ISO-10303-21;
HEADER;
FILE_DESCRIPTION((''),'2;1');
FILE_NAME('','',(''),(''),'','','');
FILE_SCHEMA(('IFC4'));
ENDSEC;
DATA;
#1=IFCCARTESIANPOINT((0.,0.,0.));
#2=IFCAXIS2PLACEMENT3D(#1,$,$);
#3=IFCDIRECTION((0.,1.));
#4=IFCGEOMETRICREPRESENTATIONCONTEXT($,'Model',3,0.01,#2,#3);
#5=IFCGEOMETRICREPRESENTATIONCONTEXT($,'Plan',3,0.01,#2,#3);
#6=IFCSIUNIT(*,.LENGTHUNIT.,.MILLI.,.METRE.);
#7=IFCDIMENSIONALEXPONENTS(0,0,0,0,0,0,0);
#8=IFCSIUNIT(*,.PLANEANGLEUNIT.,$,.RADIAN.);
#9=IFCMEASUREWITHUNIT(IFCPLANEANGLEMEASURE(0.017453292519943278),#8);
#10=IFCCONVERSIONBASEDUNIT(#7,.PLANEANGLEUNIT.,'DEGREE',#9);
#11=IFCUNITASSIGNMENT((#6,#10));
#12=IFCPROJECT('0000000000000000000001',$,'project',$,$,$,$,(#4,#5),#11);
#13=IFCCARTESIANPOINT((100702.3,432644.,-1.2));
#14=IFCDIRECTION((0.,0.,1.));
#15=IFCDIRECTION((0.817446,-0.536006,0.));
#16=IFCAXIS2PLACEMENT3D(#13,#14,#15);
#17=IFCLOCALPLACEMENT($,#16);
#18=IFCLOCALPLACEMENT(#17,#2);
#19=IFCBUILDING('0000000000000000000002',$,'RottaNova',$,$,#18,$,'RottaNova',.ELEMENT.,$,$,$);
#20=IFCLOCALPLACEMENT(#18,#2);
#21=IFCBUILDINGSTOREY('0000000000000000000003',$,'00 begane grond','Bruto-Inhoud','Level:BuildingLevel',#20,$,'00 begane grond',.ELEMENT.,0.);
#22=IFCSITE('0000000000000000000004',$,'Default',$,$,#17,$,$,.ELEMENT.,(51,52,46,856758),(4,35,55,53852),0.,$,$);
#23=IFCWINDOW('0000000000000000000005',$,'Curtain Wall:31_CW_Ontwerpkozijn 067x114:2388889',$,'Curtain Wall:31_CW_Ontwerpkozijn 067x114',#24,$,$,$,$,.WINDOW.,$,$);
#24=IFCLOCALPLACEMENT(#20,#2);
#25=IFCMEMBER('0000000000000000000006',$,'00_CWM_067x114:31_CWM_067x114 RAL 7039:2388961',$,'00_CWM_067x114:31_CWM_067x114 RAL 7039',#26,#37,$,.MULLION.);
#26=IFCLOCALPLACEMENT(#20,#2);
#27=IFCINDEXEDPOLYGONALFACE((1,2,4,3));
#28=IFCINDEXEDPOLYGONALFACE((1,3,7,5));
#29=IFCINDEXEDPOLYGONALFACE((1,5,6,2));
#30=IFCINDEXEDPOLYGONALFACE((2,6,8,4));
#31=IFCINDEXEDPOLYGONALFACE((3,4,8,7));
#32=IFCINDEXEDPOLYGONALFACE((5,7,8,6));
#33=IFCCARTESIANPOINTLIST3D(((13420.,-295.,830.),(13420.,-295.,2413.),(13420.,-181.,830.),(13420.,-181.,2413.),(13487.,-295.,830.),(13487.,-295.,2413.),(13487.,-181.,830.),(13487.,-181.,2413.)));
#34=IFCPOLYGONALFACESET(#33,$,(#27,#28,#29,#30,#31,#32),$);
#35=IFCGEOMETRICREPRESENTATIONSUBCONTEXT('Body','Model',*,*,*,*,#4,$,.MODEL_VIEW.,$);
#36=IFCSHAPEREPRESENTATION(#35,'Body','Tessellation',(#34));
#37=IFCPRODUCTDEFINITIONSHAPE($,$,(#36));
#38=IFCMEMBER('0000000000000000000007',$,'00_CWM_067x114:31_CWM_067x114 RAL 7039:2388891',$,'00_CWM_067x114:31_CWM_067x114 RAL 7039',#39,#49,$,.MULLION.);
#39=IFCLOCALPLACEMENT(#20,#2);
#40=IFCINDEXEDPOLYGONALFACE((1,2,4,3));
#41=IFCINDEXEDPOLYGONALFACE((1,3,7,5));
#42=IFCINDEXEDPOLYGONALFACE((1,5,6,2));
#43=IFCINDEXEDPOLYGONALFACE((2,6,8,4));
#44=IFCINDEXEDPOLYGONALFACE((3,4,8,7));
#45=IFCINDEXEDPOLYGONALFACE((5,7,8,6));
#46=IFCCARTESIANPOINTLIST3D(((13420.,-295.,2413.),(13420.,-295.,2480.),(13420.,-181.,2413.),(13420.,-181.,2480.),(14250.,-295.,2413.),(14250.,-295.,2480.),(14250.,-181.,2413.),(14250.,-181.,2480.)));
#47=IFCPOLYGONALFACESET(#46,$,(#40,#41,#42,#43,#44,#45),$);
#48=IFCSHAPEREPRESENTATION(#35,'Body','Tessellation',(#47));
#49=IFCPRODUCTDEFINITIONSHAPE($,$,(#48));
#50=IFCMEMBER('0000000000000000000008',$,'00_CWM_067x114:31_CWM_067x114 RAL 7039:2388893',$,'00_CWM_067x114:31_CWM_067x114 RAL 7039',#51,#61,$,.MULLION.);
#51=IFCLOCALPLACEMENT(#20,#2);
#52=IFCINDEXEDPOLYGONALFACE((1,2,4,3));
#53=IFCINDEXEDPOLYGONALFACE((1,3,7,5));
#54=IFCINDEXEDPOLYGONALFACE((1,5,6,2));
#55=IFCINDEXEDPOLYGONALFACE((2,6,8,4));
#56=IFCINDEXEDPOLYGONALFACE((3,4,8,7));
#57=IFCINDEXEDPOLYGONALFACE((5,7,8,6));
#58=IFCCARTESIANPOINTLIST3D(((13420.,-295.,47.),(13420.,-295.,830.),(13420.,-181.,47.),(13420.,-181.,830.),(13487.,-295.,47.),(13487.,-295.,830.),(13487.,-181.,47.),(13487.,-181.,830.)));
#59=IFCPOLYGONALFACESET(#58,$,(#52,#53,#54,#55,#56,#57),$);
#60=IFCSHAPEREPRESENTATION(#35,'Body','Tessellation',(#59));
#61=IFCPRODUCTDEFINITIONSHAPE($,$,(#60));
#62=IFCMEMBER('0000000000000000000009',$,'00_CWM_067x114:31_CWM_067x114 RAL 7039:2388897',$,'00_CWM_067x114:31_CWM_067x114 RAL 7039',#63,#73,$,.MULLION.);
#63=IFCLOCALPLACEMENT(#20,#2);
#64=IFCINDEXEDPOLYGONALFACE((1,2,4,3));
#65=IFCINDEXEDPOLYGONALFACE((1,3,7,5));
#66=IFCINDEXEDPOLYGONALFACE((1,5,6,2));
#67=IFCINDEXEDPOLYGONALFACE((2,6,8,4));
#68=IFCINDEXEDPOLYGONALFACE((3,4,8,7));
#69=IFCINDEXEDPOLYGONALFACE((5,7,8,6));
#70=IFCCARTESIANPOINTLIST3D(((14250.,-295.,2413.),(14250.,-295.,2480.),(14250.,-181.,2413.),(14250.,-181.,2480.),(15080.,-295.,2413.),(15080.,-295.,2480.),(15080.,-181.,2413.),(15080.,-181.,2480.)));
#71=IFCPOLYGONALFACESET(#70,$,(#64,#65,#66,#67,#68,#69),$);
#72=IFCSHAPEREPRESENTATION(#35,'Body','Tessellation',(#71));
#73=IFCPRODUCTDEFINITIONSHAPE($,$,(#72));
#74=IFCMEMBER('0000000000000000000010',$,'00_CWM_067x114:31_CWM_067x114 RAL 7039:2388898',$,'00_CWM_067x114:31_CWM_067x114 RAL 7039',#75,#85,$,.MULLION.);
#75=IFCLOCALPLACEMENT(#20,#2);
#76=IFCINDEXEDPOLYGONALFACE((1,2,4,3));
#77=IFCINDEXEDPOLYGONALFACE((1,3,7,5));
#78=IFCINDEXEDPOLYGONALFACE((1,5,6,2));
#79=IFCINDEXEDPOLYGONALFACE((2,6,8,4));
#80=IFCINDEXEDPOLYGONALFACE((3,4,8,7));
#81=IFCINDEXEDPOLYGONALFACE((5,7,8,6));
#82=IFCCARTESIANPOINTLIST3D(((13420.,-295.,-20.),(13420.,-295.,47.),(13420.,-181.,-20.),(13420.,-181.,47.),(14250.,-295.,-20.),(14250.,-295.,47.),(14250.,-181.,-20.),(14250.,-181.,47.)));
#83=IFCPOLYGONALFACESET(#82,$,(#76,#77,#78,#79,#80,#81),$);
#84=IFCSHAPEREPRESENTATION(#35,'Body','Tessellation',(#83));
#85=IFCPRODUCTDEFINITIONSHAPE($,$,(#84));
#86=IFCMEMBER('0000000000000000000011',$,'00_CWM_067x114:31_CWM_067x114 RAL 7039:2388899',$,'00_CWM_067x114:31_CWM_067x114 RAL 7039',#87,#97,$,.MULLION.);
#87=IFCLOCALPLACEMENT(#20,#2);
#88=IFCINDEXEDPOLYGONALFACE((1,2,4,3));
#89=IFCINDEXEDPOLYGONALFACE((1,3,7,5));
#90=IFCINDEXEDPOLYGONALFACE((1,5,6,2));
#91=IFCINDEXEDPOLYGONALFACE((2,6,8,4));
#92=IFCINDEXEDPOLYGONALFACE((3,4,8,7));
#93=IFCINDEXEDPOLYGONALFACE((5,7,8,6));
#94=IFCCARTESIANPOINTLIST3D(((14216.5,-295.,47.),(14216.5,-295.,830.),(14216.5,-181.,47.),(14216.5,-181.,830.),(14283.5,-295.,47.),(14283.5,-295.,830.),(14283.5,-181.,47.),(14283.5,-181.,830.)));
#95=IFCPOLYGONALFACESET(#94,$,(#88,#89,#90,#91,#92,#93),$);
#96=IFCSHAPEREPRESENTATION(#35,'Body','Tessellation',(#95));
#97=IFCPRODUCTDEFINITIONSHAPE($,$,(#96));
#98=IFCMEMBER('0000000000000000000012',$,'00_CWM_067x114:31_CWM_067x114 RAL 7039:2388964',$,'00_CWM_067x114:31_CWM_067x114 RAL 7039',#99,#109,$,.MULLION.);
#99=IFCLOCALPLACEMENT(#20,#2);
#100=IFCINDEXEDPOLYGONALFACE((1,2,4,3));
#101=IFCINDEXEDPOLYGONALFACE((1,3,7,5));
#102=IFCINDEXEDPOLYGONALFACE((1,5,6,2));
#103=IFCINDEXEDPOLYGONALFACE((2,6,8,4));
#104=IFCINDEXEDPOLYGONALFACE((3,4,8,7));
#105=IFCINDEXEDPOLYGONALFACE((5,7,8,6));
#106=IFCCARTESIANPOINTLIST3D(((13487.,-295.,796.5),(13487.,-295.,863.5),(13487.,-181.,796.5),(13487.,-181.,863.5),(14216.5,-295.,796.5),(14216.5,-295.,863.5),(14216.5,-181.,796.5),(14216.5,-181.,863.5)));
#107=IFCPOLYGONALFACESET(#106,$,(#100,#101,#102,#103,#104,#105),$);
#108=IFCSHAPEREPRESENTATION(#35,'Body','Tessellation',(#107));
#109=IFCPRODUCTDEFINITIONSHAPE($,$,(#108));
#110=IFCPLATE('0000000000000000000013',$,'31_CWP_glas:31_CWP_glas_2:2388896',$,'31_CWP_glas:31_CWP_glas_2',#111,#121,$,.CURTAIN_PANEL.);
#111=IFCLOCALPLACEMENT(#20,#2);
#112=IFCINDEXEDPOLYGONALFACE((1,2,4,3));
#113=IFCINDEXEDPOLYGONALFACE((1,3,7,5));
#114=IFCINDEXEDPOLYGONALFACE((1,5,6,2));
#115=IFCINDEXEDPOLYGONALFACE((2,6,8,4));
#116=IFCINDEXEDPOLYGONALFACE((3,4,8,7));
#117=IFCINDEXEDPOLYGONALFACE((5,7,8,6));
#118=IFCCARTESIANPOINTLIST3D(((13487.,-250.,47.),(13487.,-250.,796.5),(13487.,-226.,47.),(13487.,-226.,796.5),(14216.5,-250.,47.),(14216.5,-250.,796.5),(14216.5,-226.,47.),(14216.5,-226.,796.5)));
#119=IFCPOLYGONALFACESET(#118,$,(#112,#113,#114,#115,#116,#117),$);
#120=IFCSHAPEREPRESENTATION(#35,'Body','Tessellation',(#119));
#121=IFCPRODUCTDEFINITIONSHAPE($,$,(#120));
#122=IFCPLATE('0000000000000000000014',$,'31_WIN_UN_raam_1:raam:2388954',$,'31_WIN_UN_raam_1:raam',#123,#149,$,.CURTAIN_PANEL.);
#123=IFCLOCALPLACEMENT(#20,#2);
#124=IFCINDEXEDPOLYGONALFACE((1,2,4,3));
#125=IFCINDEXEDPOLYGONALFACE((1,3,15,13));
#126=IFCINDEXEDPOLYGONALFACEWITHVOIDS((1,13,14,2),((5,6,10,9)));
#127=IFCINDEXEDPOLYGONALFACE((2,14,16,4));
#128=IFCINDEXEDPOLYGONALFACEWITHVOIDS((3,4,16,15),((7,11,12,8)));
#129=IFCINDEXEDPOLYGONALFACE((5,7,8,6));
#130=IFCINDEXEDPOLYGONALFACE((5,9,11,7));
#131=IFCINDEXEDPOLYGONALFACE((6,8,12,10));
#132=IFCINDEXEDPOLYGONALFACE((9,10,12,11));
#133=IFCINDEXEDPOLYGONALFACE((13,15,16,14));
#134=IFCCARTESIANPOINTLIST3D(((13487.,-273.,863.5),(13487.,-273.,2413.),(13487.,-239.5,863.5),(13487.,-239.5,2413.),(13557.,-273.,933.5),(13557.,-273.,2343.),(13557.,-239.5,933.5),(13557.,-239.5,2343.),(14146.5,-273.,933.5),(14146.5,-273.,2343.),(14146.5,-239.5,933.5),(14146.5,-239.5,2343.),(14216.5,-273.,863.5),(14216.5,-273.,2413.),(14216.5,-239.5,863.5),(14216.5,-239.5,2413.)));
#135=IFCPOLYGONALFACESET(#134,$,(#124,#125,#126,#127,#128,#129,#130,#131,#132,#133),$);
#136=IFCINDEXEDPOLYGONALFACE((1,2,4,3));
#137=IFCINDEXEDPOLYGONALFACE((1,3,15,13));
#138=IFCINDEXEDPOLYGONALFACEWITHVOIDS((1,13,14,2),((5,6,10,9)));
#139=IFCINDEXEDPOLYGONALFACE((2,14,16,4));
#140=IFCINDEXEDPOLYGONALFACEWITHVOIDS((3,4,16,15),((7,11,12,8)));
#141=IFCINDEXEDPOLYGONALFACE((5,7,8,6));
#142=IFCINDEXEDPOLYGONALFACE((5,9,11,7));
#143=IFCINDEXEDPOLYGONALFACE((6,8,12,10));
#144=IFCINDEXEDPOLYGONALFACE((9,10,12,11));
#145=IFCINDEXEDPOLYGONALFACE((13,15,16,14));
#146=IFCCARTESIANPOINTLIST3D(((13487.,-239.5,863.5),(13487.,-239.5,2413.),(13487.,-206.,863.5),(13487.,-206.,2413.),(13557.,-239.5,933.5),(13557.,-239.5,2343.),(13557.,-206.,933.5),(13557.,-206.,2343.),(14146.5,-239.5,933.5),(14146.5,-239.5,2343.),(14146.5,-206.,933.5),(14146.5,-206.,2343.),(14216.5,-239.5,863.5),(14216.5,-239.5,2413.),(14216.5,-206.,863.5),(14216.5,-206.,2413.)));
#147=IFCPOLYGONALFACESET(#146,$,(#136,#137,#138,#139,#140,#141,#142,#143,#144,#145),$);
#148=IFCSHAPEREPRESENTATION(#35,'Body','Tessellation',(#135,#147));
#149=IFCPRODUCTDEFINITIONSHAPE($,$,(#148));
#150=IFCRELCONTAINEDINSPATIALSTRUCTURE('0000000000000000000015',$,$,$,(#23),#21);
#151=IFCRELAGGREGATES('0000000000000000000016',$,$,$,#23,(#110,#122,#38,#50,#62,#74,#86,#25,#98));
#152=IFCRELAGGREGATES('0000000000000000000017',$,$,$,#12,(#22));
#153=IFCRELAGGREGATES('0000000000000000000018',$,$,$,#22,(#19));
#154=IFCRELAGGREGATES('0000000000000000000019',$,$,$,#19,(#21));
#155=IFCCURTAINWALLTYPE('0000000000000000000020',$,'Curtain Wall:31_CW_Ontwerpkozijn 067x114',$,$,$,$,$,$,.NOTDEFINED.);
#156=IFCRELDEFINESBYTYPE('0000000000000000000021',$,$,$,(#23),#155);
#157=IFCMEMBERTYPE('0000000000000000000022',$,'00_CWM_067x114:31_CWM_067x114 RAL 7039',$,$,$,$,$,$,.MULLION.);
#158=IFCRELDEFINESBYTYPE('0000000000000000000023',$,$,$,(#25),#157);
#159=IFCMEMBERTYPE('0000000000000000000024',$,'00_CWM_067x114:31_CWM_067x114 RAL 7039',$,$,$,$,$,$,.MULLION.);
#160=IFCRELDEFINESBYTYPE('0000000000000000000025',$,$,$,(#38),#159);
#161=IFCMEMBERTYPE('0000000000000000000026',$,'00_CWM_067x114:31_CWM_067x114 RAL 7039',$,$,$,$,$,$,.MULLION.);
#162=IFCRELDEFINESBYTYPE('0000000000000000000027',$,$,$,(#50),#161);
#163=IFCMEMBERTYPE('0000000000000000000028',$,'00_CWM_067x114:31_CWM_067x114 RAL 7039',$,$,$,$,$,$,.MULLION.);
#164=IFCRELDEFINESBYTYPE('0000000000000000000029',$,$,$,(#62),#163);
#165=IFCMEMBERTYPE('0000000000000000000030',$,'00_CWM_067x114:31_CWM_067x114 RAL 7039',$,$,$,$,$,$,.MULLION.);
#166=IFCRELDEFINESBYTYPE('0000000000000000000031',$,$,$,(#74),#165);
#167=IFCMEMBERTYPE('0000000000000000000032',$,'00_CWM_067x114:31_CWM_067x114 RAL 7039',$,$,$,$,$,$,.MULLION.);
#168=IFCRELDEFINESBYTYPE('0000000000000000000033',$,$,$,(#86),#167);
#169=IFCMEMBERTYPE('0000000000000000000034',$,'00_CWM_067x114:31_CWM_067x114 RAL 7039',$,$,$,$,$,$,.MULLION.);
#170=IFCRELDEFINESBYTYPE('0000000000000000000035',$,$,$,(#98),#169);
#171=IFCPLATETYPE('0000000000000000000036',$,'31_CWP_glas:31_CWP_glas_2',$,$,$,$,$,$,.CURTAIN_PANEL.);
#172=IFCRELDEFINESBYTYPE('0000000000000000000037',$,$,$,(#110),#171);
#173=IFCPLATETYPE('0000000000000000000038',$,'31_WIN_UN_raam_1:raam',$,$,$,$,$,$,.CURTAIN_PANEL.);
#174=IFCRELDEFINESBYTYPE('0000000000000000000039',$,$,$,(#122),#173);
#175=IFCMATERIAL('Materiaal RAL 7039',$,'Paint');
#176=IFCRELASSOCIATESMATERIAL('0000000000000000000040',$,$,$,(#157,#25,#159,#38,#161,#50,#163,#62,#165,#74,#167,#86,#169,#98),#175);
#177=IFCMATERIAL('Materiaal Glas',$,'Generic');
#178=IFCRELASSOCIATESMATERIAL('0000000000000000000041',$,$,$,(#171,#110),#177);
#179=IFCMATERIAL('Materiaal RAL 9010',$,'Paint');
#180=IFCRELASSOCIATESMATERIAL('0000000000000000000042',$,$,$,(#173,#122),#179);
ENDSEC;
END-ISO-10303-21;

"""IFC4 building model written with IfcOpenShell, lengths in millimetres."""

from ifc_helpers import new_model, entity, si_unit, converted_unit, direction, frame, origin, place, context, subcontext, project, spatial, indexed_curve, outline, extrude, source, transform, mapped, material, type_object, type_shapes, element, aggregate, save


model = new_model("IFC4")

# Units and contexts
model_context = context("Model", 3, precision=0.01, world=origin(), true_north=direction((0.0, 1.0)))
plan_context = context("Plan", 3, precision=0.01, world=origin(), true_north=direction((0.0, 1.0)))
body_context = subcontext(model_context, "Body", "Model", "MODEL_VIEW")
ifc_project = project(units=[si_unit("LENGTHUNIT", "METRE", prefix="MILLI"), converted_unit("PLANEANGLEUNIT", "DEGREE", entity("IfcPlaneAngleMeasure", 0.017453292519943278), si_unit("PLANEANGLEUNIT", "RADIAN"), dimensions=[0, 0, 0, 0, 0, 0, 0])], contexts=[model_context, plan_context])

# Site, building, storey
site_placement = place(None, frame((100702.3, 432644.0, -1.2), z_axis=(0.0, 0.0, 1.0), x_axis=(0.817446, -0.536006, 0.0)))
site = spatial("IfcSite", under=ifc_project, at=site_placement, Name="Default", CompositionType="ELEMENT", RefLatitude=(51, 52, 46, 856758), RefLongitude=(4, 35, 55, 53852), RefElevation=0.0)
building_placement = place(site_placement, origin())
building = spatial("IfcBuilding", under=site, at=building_placement, Name="RottaNova", LongName="RottaNova", CompositionType="ELEMENT")
storey_placement = place(building_placement, origin())
storey = spatial("IfcBuildingStorey", under=building, at=storey_placement, Name="00 begane grond", Description="Bruto-Inhoud", ObjectType="Level:BuildingLevel", LongName="00 begane grond", CompositionType="ELEMENT", Elevation=0.0)

# Window, members, plates
curtain_wall_type = type_object("IfcCurtainWallType", Name="Curtain Wall:31_CW_Ontwerpkozijn 067x114", PredefinedType="NOTDEFINED")
window_1_placement = place(storey_placement, origin())
window_1 = element("IfcWindow", 1, at=window_1_placement, inside=storey, type_object=curtain_wall_type, Name="Curtain Wall:31_CW_Ontwerpkozijn 067x114:2388889", ObjectType="Curtain Wall:31_CW_Ontwerpkozijn 067x114", PredefinedType="WINDOW")
ifc_material_1 = material(Name="Materiaal RAL 7039", Category="Paint")
member_type_1 = type_object("IfcMemberType", Name="00_CWM_067x114:31_CWM_067x114 RAL 7039", PredefinedType="MULLION", material=ifc_material_1)
shared_shape_1 = source(origin(), body_context, "Body", "SweptSolid", [
    extrude(outline(indexed_curve([(-33.5, -57.0), (33.5, -57.0), (33.5, 57.0), (-33.5, 57.0), (-33.5, -57.0)], self_intersect=False)), frame((-33.5, -57.0, -1583.0), z_axis=(0.0, 0.0, 1.0), x_axis=(-1.0, 0.0, 0.0)), (0.0, 0.0, 1.0), 1583.0),
])
type_shapes(member_type_1, [shared_shape_1])
member_1_placement = place(window_1_placement, frame((13420.0, -181.0, 830.0), z_axis=(0.0, 0.0, -1.0), x_axis=(-1.0, 0.0, 0.0)))
member_1 = element("IfcMember", 2, at=member_1_placement, type_object=member_type_1, material=ifc_material_1, Name="00_CWM_067x114:31_CWM_067x114 RAL 7039:2388961", ObjectType="00_CWM_067x114:31_CWM_067x114 RAL 7039", PredefinedType="MULLION", context=body_context, shape_type="MappedRepresentation", body=[
    mapped(shared_shape_1, transform((0.0, 0.0, 0.0), scale=1.0)),
])
member_type_2 = type_object("IfcMemberType", Name="00_CWM_067x114:31_CWM_067x114 RAL 7039", PredefinedType="MULLION", material=ifc_material_1)
shared_shape_2 = source(origin(), body_context, "Body", "SweptSolid", [
    extrude(outline(indexed_curve([(-33.5, -57.0), (33.5, -57.0), (33.5, 57.0), (-33.5, 57.0), (-33.5, -57.0)], self_intersect=False)), frame((-33.5, -57.0, -830.0), z_axis=(0.0, 0.0, 1.0), x_axis=(-1.0, 0.0, 0.0)), (0.0, 0.0, 1.0), 830.0),
])
type_shapes(member_type_2, [shared_shape_2])
member_2_placement = place(window_1_placement, frame((13420.0, -181.0, 2480.0), z_axis=(-1.0, 0.0, 0.0), x_axis=(0.0, 0.0, 1.0)))
member_2 = element("IfcMember", 3, at=member_2_placement, type_object=member_type_2, material=ifc_material_1, Name="00_CWM_067x114:31_CWM_067x114 RAL 7039:2388891", ObjectType="00_CWM_067x114:31_CWM_067x114 RAL 7039", PredefinedType="MULLION", context=body_context, shape_type="MappedRepresentation", body=[
    mapped(shared_shape_2, transform((0.0, 0.0, 0.0), scale=1.0)),
])
member_type_3 = type_object("IfcMemberType", Name="00_CWM_067x114:31_CWM_067x114 RAL 7039", PredefinedType="MULLION", material=ifc_material_1)
shared_shape_3 = source(origin(), body_context, "Body", "SweptSolid", [
    extrude(outline(indexed_curve([(-33.5, -57.0), (33.5, -57.0), (33.5, 57.0), (-33.5, 57.0), (-33.5, -57.0)], self_intersect=False)), frame((-33.5, -57.0, -783.0), z_axis=(0.0, 0.0, 1.0), x_axis=(-1.0, 0.0, 0.0)), (0.0, 0.0, 1.0), 783.0),
])
type_shapes(member_type_3, [shared_shape_3])
member_3_placement = place(window_1_placement, frame((13420.0, -181.0, 47.0), z_axis=(0.0, 0.0, -1.0), x_axis=(-1.0, 0.0, 0.0)))
member_3 = element("IfcMember", 4, at=member_3_placement, type_object=member_type_3, material=ifc_material_1, Name="00_CWM_067x114:31_CWM_067x114 RAL 7039:2388893", ObjectType="00_CWM_067x114:31_CWM_067x114 RAL 7039", PredefinedType="MULLION", context=body_context, shape_type="MappedRepresentation", body=[
    mapped(shared_shape_3, transform((0.0, 0.0, 0.0), scale=1.0)),
])
member_type_4 = type_object("IfcMemberType", Name="00_CWM_067x114:31_CWM_067x114 RAL 7039", PredefinedType="MULLION", material=ifc_material_1)
shared_shape_4 = source(origin(), body_context, "Body", "SweptSolid", [
    extrude(outline(indexed_curve([(-33.5, -57.0), (33.5, -57.0), (33.5, 57.0), (-33.5, 57.0), (-33.5, -57.0)], self_intersect=False)), frame((-33.5, -57.0, -830.0), z_axis=(0.0, 0.0, 1.0), x_axis=(-1.0, 0.0, 0.0)), (0.0, 0.0, 1.0), 830.0),
])
type_shapes(member_type_4, [shared_shape_4])
member_4_placement = place(window_1_placement, frame((14250.0, -181.0, 2480.0), z_axis=(-1.0, 0.0, 0.0), x_axis=(0.0, 0.0, 1.0)))
member_4 = element("IfcMember", 5, at=member_4_placement, type_object=member_type_4, material=ifc_material_1, Name="00_CWM_067x114:31_CWM_067x114 RAL 7039:2388897", ObjectType="00_CWM_067x114:31_CWM_067x114 RAL 7039", PredefinedType="MULLION", context=body_context, shape_type="MappedRepresentation", body=[
    mapped(shared_shape_4, transform((0.0, 0.0, 0.0), scale=1.0)),
])
member_type_5 = type_object("IfcMemberType", Name="00_CWM_067x114:31_CWM_067x114 RAL 7039", PredefinedType="MULLION", material=ifc_material_1)
shared_shape_5 = source(origin(), body_context, "Body", "SweptSolid", [
    extrude(outline(indexed_curve([(-33.5, -57.0), (33.5, -57.0), (33.5, 57.0), (-33.5, 57.0), (-33.5, -57.0)], self_intersect=False)), frame((-33.5, -57.0, -830.0), z_axis=(0.0, 0.0, 1.0), x_axis=(-1.0, 0.0, 0.0)), (0.0, 0.0, 1.0), 830.0),
])
type_shapes(member_type_5, [shared_shape_5])
member_5_placement = place(window_1_placement, frame((14250.0, -181.0, -20.0), z_axis=(1.0, 0.0, 0.0), x_axis=(0.0, 0.0, -1.0)))
member_5 = element("IfcMember", 6, at=member_5_placement, type_object=member_type_5, material=ifc_material_1, Name="00_CWM_067x114:31_CWM_067x114 RAL 7039:2388898", ObjectType="00_CWM_067x114:31_CWM_067x114 RAL 7039", PredefinedType="MULLION", context=body_context, shape_type="MappedRepresentation", body=[
    mapped(shared_shape_5, transform((0.0, 0.0, 0.0), scale=1.0)),
])
member_type_6 = type_object("IfcMemberType", Name="00_CWM_067x114:31_CWM_067x114 RAL 7039", PredefinedType="MULLION", material=ifc_material_1)
shared_shape_6 = source(origin(), body_context, "Body", "SweptSolid", [
    extrude(outline(indexed_curve([(-33.5, -57.0), (33.5, -57.0), (33.5, 57.0), (-33.5, 57.0), (-33.5, -57.0)], self_intersect=False)), frame((0.0, -57.0, -783.0), z_axis=(0.0, 0.0, 1.0), x_axis=(-1.0, 0.0, 0.0)), (0.0, 0.0, 1.0), 783.0),
])
type_shapes(member_type_6, [shared_shape_6])
member_6_placement = place(window_1_placement, frame((14250.0, -181.0, 47.0), z_axis=(0.0, 0.0, -1.0), x_axis=(-1.0, 0.0, 0.0)))
member_6 = element("IfcMember", 7, at=member_6_placement, type_object=member_type_6, material=ifc_material_1, Name="00_CWM_067x114:31_CWM_067x114 RAL 7039:2388899", ObjectType="00_CWM_067x114:31_CWM_067x114 RAL 7039", PredefinedType="MULLION", context=body_context, shape_type="MappedRepresentation", body=[
    mapped(shared_shape_6, transform((0.0, 0.0, 0.0), scale=1.0)),
])
member_type_7 = type_object("IfcMemberType", Name="00_CWM_067x114:31_CWM_067x114 RAL 7039", PredefinedType="MULLION", material=ifc_material_1)
shared_shape_7 = source(origin(), body_context, "Body", "SweptSolid", [
    extrude(outline(indexed_curve([(-33.5, -57.0), (33.5, -57.0), (33.5, 57.0), (-33.5, 57.0), (-33.5, -57.0)], self_intersect=False)), frame((0.0, -57.0, -729.5), z_axis=(0.0, 0.0, 1.0), x_axis=(-1.0, 0.0, 0.0)), (0.0, 0.0, 1.0), 729.5),
])
type_shapes(member_type_7, [shared_shape_7])
member_7_placement = place(window_1_placement, frame((13487.0, -181.0, 830.0), z_axis=(-1.0, 0.0, 0.0), x_axis=(0.0, 0.0, 1.0)))
member_7 = element("IfcMember", 8, at=member_7_placement, type_object=member_type_7, material=ifc_material_1, Name="00_CWM_067x114:31_CWM_067x114 RAL 7039:2388964", ObjectType="00_CWM_067x114:31_CWM_067x114 RAL 7039", PredefinedType="MULLION", context=body_context, shape_type="MappedRepresentation", body=[
    mapped(shared_shape_7, transform((0.0, 0.0, 0.0), scale=1.0)),
])
ifc_material_2 = material(Name="Materiaal Glas", Category="Generic")
plate_type_1 = type_object("IfcPlateType", Name="31_CWP_glas:31_CWP_glas_2", PredefinedType="CURTAIN_PANEL", material=ifc_material_2)
shared_shape_8 = source(origin(), body_context, "Body", "SweptSolid", [
    extrude(outline(indexed_curve([(-12.0, -364.7), (12.0, -364.7), (12.0, 364.7), (-12.0, 364.7), (-12.0, -364.7)], self_intersect=False)), frame((0.0, 57.0, 0.0), z_axis=(0.0, 0.0, 1.0), x_axis=(0.0, 1.0, 0.0)), (0.0, 0.0, 1.0), 749.5),
])
type_shapes(plate_type_1, [shared_shape_8])
plate_1_placement = place(window_1_placement, frame((13851.8, -181.0, 47.0), z_axis=(0.0, 0.0, 1.0), x_axis=(-1.0, 0.0, 0.0)))
plate_1 = element("IfcPlate", 9, at=plate_1_placement, type_object=plate_type_1, material=ifc_material_2, Name="31_CWP_glas:31_CWP_glas_2:2388896", ObjectType="31_CWP_glas:31_CWP_glas_2", PredefinedType="CURTAIN_PANEL", context=body_context, shape_type="MappedRepresentation", body=[
    mapped(shared_shape_8, transform((0.0, 0.0, 0.0), scale=1.0)),
])
ifc_material_3 = material(Name="Materiaal RAL 9010", Category="Paint")
plate_type_2 = type_object("IfcPlateType", Name="31_WIN_UN_raam_1:raam", PredefinedType="CURTAIN_PANEL", material=ifc_material_3)
shared_shape_9 = source(origin(), body_context, "Body", "SweptSolid", [
    extrude(outline(indexed_curve([(-364.7, -774.7), (364.7, -774.7), (364.7, 774.7), (-364.7, 774.7), (-364.7, -774.7)], self_intersect=False), holes=[indexed_curve([(-294.7, 704.7), (294.7, 704.7), (294.7, -704.8), (-294.7, -704.8), (-294.7, 704.7)], self_intersect=False)]), frame((0.0, 58.5, 774.8), z_axis=(0.0, 1.0, 0.0), x_axis=(1.0, 0.0, 0.0)), (0.0, 0.0, 1.0), 33.5),
    extrude(outline(indexed_curve([(-364.7, -774.7), (364.7, -774.7), (364.7, 774.7), (-364.7, 774.7), (-364.7, -774.7)], self_intersect=False), holes=[indexed_curve([(-294.7, 704.7), (294.7, 704.7), (294.7, -704.8), (-294.7, -704.8), (-294.7, 704.7)], self_intersect=False)]), frame((0.0, 25.0, 774.8), z_axis=(0.0, 1.0, 0.0), x_axis=(1.0, 0.0, 0.0)), (0.0, 0.0, 1.0), 33.5),
])
type_shapes(plate_type_2, [shared_shape_9])
plate_2_placement = place(window_1_placement, frame((13851.8, -181.0, 863.5), z_axis=(0.0, 0.0, 1.0), x_axis=(-1.0, 0.0, 0.0)))
plate_2 = element("IfcPlate", 10, at=plate_2_placement, type_object=plate_type_2, material=ifc_material_3, Name="31_WIN_UN_raam_1:raam:2388954", ObjectType="31_WIN_UN_raam_1:raam", PredefinedType="CURTAIN_PANEL", context=body_context, shape_type="MappedRepresentation", body=[
    mapped(shared_shape_9, transform((0.0, 0.0, 0.0), scale=1.0)),
])
aggregate(window_1, [plate_1, plate_2, member_2, member_3, member_4, member_5, member_6, member_1, member_7])

save(model, "model.ifc")
